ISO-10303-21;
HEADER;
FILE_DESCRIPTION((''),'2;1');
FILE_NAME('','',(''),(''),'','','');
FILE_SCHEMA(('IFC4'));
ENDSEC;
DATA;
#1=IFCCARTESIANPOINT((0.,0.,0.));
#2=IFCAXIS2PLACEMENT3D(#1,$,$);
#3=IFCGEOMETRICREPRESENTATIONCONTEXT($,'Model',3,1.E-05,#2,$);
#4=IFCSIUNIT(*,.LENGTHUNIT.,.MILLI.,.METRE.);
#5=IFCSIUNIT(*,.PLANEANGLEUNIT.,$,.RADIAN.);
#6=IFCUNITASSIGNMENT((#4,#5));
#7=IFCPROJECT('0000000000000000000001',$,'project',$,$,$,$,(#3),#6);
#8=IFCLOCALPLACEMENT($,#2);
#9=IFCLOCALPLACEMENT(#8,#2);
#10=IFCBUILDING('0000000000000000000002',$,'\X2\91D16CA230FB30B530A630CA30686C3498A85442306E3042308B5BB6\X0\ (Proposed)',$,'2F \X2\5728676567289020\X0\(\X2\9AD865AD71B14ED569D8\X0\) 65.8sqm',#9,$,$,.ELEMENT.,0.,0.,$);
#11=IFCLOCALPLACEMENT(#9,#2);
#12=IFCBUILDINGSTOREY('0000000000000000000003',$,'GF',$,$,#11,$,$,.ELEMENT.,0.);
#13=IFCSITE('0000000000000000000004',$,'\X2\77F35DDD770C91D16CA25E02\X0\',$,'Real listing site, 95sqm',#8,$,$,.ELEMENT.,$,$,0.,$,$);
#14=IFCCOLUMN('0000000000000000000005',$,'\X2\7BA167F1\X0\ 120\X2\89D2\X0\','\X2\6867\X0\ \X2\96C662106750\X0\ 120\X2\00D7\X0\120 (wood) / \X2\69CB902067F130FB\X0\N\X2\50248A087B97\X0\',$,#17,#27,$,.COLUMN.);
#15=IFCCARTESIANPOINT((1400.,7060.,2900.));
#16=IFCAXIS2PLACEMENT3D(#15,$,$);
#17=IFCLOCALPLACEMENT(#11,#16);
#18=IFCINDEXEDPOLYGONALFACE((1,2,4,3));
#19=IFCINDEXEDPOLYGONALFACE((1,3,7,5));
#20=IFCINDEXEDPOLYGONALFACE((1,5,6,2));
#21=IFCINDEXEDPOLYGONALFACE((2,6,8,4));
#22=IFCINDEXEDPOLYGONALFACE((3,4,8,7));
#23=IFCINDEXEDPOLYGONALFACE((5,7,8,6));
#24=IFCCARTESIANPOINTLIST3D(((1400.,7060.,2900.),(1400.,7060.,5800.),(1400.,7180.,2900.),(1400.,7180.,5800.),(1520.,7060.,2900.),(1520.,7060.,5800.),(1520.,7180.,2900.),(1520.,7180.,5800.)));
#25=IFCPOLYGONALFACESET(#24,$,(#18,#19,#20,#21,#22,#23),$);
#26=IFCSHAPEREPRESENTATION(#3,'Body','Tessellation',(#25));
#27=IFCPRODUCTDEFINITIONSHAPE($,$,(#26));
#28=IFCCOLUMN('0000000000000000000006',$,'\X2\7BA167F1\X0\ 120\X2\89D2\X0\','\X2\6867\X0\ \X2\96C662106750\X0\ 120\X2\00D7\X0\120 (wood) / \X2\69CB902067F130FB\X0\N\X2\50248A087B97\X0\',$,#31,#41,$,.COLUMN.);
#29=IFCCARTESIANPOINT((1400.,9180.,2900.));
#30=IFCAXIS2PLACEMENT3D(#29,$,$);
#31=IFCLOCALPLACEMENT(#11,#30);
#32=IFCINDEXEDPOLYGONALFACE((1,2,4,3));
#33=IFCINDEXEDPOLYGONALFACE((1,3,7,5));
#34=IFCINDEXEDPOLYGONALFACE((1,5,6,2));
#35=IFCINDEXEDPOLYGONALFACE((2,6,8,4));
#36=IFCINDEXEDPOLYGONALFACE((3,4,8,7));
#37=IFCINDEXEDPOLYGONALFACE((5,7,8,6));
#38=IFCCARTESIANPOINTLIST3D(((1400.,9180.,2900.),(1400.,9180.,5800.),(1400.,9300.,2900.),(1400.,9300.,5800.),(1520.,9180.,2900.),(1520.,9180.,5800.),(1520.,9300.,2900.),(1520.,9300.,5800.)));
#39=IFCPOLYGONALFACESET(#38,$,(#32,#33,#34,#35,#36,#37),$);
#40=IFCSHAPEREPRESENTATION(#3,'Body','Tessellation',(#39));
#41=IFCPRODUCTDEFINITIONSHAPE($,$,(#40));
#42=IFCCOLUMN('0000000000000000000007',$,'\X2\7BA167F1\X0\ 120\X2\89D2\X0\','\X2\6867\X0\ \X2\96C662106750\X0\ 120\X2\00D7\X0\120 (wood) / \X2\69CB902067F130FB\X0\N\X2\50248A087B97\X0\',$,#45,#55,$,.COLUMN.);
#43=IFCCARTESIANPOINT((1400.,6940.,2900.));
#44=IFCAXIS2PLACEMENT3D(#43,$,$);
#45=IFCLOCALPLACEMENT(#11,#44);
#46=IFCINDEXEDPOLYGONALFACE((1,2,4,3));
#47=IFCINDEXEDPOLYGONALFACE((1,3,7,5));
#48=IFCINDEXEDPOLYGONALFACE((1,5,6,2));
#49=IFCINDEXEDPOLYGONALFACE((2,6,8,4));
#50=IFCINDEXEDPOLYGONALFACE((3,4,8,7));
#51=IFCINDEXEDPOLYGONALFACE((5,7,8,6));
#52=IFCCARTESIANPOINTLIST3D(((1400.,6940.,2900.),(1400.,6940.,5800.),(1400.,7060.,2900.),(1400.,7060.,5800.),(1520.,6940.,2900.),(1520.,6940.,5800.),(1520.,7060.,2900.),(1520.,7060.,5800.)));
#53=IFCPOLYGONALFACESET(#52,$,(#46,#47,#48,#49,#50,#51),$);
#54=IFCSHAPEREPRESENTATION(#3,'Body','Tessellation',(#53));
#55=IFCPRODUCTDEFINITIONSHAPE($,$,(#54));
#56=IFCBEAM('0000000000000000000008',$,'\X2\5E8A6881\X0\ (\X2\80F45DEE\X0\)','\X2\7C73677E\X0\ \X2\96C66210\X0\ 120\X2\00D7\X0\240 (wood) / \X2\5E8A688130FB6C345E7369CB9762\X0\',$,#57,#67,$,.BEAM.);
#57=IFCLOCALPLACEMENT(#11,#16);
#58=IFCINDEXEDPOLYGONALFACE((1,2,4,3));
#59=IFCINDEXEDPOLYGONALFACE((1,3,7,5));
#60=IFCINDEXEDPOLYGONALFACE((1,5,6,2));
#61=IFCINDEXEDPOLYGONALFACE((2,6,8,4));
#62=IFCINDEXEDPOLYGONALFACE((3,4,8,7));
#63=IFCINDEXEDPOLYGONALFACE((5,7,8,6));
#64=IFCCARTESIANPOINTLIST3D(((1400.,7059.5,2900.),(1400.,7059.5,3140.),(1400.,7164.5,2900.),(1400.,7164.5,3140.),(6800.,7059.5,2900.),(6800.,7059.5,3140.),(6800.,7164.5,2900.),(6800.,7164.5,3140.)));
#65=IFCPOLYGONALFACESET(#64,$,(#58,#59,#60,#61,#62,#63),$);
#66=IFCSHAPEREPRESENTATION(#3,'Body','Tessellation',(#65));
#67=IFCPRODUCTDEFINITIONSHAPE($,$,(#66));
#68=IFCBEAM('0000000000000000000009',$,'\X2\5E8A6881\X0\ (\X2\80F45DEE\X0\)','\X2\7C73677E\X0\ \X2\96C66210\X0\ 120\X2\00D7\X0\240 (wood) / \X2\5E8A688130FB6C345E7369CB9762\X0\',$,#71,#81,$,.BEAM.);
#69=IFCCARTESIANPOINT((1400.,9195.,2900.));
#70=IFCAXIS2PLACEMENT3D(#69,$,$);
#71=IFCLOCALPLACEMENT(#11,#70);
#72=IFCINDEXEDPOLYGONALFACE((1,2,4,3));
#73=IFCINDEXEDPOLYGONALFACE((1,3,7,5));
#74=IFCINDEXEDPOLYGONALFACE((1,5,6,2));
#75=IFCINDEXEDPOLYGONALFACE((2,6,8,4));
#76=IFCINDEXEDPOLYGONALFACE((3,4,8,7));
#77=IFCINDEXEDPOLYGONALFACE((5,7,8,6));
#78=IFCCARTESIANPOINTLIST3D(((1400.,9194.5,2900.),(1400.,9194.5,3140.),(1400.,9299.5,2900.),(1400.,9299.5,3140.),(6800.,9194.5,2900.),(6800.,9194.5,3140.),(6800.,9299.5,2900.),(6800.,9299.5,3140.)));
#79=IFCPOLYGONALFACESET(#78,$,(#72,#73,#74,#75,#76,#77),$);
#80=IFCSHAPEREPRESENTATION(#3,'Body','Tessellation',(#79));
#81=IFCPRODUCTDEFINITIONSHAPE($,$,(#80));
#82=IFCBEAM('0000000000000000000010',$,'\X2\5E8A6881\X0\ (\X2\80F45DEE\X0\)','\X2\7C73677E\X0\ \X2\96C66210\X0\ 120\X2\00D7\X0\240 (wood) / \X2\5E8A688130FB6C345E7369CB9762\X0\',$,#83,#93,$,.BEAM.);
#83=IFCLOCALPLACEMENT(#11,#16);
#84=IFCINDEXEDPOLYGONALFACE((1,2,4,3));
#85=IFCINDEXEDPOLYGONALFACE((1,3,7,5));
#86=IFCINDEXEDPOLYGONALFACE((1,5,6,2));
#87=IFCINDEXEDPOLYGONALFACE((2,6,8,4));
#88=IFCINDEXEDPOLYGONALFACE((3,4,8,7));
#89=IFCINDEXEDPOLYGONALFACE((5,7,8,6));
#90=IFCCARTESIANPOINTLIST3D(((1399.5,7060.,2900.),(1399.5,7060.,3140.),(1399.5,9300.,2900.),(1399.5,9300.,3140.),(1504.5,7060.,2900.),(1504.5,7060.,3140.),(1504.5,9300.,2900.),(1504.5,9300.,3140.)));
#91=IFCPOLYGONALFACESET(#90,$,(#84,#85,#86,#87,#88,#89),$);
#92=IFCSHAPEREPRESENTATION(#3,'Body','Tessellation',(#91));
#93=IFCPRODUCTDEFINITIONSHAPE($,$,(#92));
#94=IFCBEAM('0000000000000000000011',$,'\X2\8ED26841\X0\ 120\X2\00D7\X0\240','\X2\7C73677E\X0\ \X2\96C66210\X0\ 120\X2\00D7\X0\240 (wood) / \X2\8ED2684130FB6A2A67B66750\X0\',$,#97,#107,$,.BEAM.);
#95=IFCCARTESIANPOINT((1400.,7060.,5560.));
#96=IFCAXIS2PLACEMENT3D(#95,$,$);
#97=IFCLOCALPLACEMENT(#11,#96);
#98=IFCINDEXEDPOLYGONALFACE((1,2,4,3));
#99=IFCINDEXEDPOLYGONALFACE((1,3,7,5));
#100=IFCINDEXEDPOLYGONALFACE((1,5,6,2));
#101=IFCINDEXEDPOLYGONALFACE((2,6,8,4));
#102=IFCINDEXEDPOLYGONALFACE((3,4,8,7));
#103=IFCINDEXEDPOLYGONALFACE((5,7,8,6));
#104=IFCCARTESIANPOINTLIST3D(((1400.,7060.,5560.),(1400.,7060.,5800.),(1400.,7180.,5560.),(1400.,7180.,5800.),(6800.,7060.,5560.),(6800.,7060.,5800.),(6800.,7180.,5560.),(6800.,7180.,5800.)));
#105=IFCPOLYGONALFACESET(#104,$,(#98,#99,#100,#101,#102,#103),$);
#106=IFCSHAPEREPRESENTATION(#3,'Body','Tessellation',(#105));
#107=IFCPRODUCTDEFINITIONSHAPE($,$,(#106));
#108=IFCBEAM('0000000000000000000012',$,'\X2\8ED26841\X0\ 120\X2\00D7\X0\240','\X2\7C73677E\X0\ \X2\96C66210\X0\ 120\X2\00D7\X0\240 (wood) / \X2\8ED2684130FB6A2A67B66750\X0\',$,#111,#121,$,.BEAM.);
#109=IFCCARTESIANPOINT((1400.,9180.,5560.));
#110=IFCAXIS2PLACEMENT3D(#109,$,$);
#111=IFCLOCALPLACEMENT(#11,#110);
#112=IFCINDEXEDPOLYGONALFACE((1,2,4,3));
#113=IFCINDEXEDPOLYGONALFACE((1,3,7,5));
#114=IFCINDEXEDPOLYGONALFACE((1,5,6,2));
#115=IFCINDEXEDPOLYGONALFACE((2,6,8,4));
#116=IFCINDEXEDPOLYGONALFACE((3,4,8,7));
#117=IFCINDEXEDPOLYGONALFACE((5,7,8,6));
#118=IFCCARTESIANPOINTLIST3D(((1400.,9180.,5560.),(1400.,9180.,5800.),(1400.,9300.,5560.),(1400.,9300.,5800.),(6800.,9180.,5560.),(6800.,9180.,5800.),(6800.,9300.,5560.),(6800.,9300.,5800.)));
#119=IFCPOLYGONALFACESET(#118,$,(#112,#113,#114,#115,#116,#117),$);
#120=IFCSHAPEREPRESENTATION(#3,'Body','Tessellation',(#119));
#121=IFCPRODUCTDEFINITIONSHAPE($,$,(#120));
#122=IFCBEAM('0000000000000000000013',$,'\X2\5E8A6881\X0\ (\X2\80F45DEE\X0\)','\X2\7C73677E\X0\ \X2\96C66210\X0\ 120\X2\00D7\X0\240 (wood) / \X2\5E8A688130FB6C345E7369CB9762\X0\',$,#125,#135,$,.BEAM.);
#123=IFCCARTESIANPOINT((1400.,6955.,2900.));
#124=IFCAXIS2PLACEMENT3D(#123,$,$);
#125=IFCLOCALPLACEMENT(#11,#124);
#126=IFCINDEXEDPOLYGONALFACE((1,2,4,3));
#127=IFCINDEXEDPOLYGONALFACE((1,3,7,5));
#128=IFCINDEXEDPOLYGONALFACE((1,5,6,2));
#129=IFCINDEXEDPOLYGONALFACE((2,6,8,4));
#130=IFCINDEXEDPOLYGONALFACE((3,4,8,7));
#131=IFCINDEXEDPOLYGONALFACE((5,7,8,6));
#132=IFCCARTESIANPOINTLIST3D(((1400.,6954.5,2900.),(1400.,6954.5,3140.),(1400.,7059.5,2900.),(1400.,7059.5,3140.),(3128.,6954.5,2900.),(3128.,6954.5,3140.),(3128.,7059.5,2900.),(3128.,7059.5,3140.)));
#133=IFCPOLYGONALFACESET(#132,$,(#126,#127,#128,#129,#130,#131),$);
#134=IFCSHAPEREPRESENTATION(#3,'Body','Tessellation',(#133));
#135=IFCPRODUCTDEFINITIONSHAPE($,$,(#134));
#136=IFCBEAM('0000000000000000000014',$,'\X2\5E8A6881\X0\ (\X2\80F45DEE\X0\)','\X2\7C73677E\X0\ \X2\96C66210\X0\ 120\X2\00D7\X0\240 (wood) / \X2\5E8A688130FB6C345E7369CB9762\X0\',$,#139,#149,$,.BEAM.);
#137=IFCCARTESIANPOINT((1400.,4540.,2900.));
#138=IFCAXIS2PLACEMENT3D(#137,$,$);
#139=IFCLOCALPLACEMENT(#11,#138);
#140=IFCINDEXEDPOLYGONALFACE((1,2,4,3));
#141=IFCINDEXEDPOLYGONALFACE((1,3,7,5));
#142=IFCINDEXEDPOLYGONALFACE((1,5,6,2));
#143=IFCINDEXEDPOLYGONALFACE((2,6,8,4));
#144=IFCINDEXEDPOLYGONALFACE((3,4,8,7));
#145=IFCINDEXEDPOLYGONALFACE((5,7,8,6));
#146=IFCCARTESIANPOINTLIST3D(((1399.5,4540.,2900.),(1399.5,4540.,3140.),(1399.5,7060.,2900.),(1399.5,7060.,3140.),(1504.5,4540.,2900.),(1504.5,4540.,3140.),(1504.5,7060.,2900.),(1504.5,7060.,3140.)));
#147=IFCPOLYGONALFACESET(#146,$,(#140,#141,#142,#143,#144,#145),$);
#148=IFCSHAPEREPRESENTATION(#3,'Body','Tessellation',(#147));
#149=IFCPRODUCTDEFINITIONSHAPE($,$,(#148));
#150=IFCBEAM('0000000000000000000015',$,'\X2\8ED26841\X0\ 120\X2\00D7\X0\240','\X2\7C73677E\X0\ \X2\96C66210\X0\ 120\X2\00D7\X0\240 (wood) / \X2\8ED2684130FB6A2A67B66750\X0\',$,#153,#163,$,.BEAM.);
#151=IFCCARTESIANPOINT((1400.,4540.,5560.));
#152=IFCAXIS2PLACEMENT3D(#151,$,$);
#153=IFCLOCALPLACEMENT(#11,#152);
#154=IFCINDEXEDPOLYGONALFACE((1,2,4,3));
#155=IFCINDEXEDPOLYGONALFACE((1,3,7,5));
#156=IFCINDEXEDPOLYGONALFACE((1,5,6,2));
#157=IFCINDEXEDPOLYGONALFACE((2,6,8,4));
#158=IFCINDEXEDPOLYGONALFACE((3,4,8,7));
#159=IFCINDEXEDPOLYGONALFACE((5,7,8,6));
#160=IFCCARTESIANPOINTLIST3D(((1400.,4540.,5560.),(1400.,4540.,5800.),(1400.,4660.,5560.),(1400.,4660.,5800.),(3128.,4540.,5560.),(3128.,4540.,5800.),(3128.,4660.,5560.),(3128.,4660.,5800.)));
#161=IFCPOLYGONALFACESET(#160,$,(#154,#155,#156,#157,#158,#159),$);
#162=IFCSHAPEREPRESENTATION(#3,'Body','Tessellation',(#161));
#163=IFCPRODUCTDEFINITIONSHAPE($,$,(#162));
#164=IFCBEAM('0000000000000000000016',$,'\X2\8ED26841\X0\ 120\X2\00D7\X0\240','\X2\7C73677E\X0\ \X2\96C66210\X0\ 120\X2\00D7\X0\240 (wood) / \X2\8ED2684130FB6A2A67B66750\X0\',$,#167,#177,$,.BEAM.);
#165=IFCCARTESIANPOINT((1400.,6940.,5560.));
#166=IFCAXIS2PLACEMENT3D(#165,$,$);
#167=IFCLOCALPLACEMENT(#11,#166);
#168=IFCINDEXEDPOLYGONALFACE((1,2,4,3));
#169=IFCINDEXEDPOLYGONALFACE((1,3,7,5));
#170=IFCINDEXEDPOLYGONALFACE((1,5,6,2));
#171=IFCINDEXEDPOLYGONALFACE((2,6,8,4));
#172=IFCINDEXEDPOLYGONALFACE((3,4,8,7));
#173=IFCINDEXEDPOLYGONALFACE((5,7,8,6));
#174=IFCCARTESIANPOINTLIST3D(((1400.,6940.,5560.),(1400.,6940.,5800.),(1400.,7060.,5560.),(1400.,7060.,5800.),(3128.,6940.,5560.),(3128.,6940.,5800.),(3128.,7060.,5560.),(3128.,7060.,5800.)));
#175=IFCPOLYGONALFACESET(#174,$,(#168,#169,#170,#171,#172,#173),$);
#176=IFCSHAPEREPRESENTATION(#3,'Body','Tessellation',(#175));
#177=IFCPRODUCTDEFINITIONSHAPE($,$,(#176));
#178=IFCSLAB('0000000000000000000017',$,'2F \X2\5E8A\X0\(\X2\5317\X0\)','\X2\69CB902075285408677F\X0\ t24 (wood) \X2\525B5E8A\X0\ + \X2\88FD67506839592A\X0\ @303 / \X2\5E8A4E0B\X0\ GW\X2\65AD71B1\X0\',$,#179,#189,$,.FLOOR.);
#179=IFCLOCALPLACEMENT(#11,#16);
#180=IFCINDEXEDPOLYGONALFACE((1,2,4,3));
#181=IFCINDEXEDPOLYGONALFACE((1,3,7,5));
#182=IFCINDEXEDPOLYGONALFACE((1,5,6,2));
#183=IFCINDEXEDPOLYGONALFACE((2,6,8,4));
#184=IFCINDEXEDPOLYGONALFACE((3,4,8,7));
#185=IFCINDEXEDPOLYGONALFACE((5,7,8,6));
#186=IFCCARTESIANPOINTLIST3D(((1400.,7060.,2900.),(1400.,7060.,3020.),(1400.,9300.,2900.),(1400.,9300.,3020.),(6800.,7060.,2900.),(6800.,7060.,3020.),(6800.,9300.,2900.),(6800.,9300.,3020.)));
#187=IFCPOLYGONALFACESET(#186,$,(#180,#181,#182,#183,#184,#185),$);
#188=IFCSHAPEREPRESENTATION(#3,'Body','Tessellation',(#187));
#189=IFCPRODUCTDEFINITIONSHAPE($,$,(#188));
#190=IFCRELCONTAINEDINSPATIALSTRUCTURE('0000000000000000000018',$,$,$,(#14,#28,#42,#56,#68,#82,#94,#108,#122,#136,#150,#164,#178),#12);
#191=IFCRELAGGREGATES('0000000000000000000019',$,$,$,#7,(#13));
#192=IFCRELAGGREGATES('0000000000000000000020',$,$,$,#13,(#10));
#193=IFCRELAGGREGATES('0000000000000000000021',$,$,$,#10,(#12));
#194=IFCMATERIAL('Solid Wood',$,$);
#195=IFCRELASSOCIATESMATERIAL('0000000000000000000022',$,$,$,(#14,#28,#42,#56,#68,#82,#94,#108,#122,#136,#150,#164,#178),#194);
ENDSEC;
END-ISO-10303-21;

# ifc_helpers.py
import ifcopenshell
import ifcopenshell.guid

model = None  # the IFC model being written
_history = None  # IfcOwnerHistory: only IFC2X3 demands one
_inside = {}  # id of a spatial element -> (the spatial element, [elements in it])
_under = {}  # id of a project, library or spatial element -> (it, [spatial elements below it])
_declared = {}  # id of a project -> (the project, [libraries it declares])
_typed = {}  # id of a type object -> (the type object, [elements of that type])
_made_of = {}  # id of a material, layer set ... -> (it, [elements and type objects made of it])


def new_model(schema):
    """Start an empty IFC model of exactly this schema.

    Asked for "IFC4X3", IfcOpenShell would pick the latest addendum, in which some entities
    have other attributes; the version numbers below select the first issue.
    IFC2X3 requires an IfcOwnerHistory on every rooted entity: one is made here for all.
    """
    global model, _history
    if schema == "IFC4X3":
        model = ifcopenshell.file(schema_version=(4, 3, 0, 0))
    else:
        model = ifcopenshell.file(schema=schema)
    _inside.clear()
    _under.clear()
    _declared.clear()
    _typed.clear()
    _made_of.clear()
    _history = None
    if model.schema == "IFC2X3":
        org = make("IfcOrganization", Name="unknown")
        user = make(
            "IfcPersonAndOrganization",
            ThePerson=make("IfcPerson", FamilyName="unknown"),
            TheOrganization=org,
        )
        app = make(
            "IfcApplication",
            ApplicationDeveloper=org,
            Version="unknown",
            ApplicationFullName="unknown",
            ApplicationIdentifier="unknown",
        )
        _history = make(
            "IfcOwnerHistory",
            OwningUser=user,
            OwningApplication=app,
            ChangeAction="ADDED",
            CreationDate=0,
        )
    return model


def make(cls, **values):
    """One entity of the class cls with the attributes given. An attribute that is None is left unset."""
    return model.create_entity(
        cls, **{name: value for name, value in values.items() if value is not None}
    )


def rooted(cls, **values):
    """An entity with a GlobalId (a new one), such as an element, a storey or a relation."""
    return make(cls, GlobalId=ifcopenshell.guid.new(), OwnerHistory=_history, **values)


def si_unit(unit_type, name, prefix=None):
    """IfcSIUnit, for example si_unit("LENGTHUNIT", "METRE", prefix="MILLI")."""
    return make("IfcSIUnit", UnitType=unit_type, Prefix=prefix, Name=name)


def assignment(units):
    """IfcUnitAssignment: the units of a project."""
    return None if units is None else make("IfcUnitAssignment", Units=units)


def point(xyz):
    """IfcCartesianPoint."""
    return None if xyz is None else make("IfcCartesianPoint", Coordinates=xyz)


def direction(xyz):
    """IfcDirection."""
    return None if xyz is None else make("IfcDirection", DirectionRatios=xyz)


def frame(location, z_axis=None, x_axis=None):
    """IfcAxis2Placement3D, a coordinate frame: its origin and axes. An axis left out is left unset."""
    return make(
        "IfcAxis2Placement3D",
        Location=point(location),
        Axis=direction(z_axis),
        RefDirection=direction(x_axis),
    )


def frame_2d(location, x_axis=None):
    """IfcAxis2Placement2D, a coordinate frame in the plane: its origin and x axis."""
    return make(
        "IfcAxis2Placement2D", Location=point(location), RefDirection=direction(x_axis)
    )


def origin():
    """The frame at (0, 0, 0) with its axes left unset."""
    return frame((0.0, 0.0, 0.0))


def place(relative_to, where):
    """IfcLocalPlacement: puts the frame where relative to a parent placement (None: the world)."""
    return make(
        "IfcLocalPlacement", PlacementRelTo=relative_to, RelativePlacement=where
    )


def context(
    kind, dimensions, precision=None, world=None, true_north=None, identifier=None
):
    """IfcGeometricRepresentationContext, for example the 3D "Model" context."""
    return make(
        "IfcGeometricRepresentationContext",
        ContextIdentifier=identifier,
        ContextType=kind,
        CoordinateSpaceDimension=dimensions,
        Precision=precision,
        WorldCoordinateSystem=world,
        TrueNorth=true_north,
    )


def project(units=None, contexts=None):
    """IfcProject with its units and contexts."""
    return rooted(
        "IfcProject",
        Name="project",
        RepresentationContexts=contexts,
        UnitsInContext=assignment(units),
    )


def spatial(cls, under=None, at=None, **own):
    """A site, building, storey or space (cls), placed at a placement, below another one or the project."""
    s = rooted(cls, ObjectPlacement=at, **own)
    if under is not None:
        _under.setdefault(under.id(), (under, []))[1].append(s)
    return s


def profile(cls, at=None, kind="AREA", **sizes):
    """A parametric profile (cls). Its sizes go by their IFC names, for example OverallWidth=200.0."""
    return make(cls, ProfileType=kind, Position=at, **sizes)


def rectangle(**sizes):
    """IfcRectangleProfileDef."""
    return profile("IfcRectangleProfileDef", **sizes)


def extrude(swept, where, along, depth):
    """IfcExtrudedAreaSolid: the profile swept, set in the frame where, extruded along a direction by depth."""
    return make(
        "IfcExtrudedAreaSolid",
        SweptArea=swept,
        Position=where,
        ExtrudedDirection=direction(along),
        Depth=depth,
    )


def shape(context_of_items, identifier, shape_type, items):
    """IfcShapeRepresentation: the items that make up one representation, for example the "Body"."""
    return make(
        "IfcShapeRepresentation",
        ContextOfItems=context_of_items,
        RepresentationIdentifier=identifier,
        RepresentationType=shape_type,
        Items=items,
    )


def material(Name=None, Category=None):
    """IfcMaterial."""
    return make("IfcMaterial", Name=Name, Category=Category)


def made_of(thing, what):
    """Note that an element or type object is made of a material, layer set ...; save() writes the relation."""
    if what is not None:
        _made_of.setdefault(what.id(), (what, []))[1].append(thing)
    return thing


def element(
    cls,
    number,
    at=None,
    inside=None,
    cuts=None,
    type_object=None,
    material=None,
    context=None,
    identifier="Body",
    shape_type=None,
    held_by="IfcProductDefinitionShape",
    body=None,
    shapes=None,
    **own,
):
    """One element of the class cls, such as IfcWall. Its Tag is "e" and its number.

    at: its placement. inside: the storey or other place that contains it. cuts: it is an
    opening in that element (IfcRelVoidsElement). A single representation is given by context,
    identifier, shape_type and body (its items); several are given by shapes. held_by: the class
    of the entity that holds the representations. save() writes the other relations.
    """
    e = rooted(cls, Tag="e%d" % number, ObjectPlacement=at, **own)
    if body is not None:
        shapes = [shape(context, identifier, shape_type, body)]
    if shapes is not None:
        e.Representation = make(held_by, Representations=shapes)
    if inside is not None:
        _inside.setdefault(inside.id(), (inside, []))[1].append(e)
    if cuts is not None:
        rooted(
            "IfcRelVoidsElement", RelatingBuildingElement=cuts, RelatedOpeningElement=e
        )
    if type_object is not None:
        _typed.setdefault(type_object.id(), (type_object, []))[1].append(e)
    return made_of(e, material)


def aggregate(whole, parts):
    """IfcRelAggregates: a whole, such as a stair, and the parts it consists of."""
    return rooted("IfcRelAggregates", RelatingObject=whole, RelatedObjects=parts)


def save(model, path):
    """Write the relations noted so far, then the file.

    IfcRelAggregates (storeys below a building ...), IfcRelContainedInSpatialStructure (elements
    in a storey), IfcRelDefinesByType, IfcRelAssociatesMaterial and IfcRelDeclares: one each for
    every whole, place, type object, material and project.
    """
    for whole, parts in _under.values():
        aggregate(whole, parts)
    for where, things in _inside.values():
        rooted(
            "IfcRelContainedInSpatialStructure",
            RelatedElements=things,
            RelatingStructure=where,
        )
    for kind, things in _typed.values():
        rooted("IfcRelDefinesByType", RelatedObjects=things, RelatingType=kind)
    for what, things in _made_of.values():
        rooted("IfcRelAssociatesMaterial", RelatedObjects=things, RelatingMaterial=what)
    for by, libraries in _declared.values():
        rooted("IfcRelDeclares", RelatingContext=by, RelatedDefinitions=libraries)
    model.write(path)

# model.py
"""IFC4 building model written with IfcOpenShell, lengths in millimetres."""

from ifc_helpers import new_model, si_unit, frame, frame_2d, origin, place, context, project, spatial, rectangle, extrude, material, element, save


model = new_model("IFC4")

# Units and contexts
model_context = context("Model", 3, precision=1e-05, world=origin())
ifc_project = project(units=[si_unit("LENGTHUNIT", "METRE", prefix="MILLI"), si_unit("PLANEANGLEUNIT", "RADIAN")], contexts=[model_context])

# Site, building, storey
site_placement = place(None, origin())
site = spatial("IfcSite", under=ifc_project, at=site_placement, Name="石川県金沢市", ObjectType="Real listing site, 95sqm", CompositionType="ELEMENT", RefElevation=0.0)
building_placement = place(site_placement, origin())
building = spatial("IfcBuilding", under=site, at=building_placement, Name="金沢・サウナと水風呂のある家 (Proposed)", ObjectType="2F 在来木造(高断熱仕様) 65.8sqm", CompositionType="ELEMENT", ElevationOfRefHeight=0.0, ElevationOfTerrain=0.0)
storey_placement = place(building_placement, origin())
storey = spatial("IfcBuildingStorey", under=building, at=storey_placement, Name="GF", CompositionType="ELEMENT", Elevation=0.0)

# Columns
ifc_material_1 = material(Name="Solid Wood")
column_1_placement = place(storey_placement, frame((1400.0, 7060.0, 2900.0)))
element("IfcColumn", 1, at=column_1_placement, inside=storey, material=ifc_material_1, Name="管柱 120角", Description="桧 集成材 120×120 (wood) / 構造柱・N値計算", PredefinedType="COLUMN", context=model_context, shape_type="SweptSolid", body=[
    extrude(rectangle(XDim=120.0, YDim=120.0, at=frame_2d((60.0, 60.0))), frame((1400.0, 7060.0, 2900.0)), (0.0, 0.0, 1.0), 2900.0),
])
column_2_placement = place(storey_placement, frame((1400.0, 9180.0, 2900.0)))
element("IfcColumn", 2, at=column_2_placement, inside=storey, material=ifc_material_1, Name="管柱 120角", Description="桧 集成材 120×120 (wood) / 構造柱・N値計算", PredefinedType="COLUMN", context=model_context, shape_type="SweptSolid", body=[
    extrude(rectangle(XDim=120.0, YDim=120.0, at=frame_2d((60.0, 60.0))), frame((1400.0, 9180.0, 2900.0)), (0.0, 0.0, 1.0), 2900.0),
])
column_3_placement = place(storey_placement, frame((1400.0, 6940.0, 2900.0)))
element("IfcColumn", 3, at=column_3_placement, inside=storey, material=ifc_material_1, Name="管柱 120角", Description="桧 集成材 120×120 (wood) / 構造柱・N値計算", PredefinedType="COLUMN", context=model_context, shape_type="SweptSolid", body=[
    extrude(rectangle(XDim=120.0, YDim=120.0, at=frame_2d((60.0, 60.0))), frame((1400.0, 6940.0, 2900.0)), (0.0, 0.0, 1.0), 2900.0),
])

# Beams
beam_1_placement = place(storey_placement, frame((1400.0, 7060.0, 2900.0)))
element("IfcBeam", 4, at=beam_1_placement, inside=storey, material=ifc_material_1, Name="床梁 (胴差)", Description="米松 集成 120×240 (wood) / 床梁・水平構面", PredefinedType="BEAM", context=model_context, shape_type="SweptSolid", body=[
    extrude(rectangle(XDim=5400.0, YDim=105.0, at=frame_2d((2700.0, 52.0))), frame((1400.0, 7060.0, 2900.0)), (0.0, 0.0, 1.0), 240.0),
])
beam_2_placement = place(storey_placement, frame((1400.0, 9195.0, 2900.0)))
element("IfcBeam", 5, at=beam_2_placement, inside=storey, material=ifc_material_1, Name="床梁 (胴差)", Description="米松 集成 120×240 (wood) / 床梁・水平構面", PredefinedType="BEAM", context=model_context, shape_type="SweptSolid", body=[
    extrude(rectangle(XDim=5400.0, YDim=105.0, at=frame_2d((2700.0, 52.0))), frame((1400.0, 9195.0, 2900.0)), (0.0, 0.0, 1.0), 240.0),
])
beam_3_placement = place(storey_placement, frame((1400.0, 7060.0, 2900.0)))
element("IfcBeam", 6, at=beam_3_placement, inside=storey, material=ifc_material_1, Name="床梁 (胴差)", Description="米松 集成 120×240 (wood) / 床梁・水平構面", PredefinedType="BEAM", context=model_context, shape_type="SweptSolid", body=[
    extrude(rectangle(XDim=105.0, YDim=2240.0, at=frame_2d((52.0, 1120.0))), frame((1400.0, 7060.0, 2900.0)), (0.0, 0.0, 1.0), 240.0),
])
beam_4_placement = place(storey_placement, frame((1400.0, 7060.0, 5560.0)))
element("IfcBeam", 7, at=beam_4_placement, inside=storey, material=ifc_material_1, Name="軒桁 120×240", Description="米松 集成 120×240 (wood) / 軒桁・横架材", PredefinedType="BEAM", context=model_context, shape_type="SweptSolid", body=[
    extrude(rectangle(XDim=5400.0, YDim=120.0, at=frame_2d((2700.0, 60.0))), frame((1400.0, 7060.0, 5560.0)), (0.0, 0.0, 1.0), 240.0),
])
beam_5_placement = place(storey_placement, frame((1400.0, 9180.0, 5560.0)))
element("IfcBeam", 8, at=beam_5_placement, inside=storey, material=ifc_material_1, Name="軒桁 120×240", Description="米松 集成 120×240 (wood) / 軒桁・横架材", PredefinedType="BEAM", context=model_context, shape_type="SweptSolid", body=[
    extrude(rectangle(XDim=5400.0, YDim=120.0, at=frame_2d((2700.0, 60.0))), frame((1400.0, 9180.0, 5560.0)), (0.0, 0.0, 1.0), 240.0),
])
beam_6_placement = place(storey_placement, frame((1400.0, 6955.0, 2900.0)))
element("IfcBeam", 9, at=beam_6_placement, inside=storey, material=ifc_material_1, Name="床梁 (胴差)", Description="米松 集成 120×240 (wood) / 床梁・水平構面", PredefinedType="BEAM", context=model_context, shape_type="SweptSolid", body=[
    extrude(rectangle(XDim=1728.0, YDim=105.0, at=frame_2d((864.0, 52.0))), frame((1400.0, 6955.0, 2900.0)), (0.0, 0.0, 1.0), 240.0),
])
beam_7_placement = place(storey_placement, frame((1400.0, 4540.0, 2900.0)))
element("IfcBeam", 10, at=beam_7_placement, inside=storey, material=ifc_material_1, Name="床梁 (胴差)", Description="米松 集成 120×240 (wood) / 床梁・水平構面", PredefinedType="BEAM", context=model_context, shape_type="SweptSolid", body=[
    extrude(rectangle(XDim=105.0, YDim=2520.0, at=frame_2d((52.0, 1260.0))), frame((1400.0, 4540.0, 2900.0)), (0.0, 0.0, 1.0), 240.0),
])
beam_8_placement = place(storey_placement, frame((1400.0, 4540.0, 5560.0)))
element("IfcBeam", 11, at=beam_8_placement, inside=storey, material=ifc_material_1, Name="軒桁 120×240", Description="米松 集成 120×240 (wood) / 軒桁・横架材", PredefinedType="BEAM", context=model_context, shape_type="SweptSolid", body=[
    extrude(rectangle(XDim=1728.0, YDim=120.0, at=frame_2d((864.0, 60.0))), frame((1400.0, 4540.0, 5560.0)), (0.0, 0.0, 1.0), 240.0),
])
beam_9_placement = place(storey_placement, frame((1400.0, 6940.0, 5560.0)))
element("IfcBeam", 12, at=beam_9_placement, inside=storey, material=ifc_material_1, Name="軒桁 120×240", Description="米松 集成 120×240 (wood) / 軒桁・横架材", PredefinedType="BEAM", context=model_context, shape_type="SweptSolid", body=[
    extrude(rectangle(XDim=1728.0, YDim=120.0, at=frame_2d((864.0, 60.0))), frame((1400.0, 6940.0, 5560.0)), (0.0, 0.0, 1.0), 240.0),
])

# Slab
slab_placement = place(storey_placement, frame((1400.0, 7060.0, 2900.0)))
element("IfcSlab", 13, at=slab_placement, inside=storey, material=ifc_material_1, Name="2F 床(北)", Description="構造用合板 t24 (wood) 剛床 + 製材根太 @303 / 床下 GW断熱", PredefinedType="FLOOR", context=model_context, shape_type="SweptSolid", body=[
    extrude(rectangle(XDim=5400.0, YDim=2240.0, at=frame_2d((2700.0, 1120.0))), frame((1400.0, 7060.0, 2900.0)), (0.0, 0.0, 1.0), 120.0),
])

save(model, "model.ifc")
